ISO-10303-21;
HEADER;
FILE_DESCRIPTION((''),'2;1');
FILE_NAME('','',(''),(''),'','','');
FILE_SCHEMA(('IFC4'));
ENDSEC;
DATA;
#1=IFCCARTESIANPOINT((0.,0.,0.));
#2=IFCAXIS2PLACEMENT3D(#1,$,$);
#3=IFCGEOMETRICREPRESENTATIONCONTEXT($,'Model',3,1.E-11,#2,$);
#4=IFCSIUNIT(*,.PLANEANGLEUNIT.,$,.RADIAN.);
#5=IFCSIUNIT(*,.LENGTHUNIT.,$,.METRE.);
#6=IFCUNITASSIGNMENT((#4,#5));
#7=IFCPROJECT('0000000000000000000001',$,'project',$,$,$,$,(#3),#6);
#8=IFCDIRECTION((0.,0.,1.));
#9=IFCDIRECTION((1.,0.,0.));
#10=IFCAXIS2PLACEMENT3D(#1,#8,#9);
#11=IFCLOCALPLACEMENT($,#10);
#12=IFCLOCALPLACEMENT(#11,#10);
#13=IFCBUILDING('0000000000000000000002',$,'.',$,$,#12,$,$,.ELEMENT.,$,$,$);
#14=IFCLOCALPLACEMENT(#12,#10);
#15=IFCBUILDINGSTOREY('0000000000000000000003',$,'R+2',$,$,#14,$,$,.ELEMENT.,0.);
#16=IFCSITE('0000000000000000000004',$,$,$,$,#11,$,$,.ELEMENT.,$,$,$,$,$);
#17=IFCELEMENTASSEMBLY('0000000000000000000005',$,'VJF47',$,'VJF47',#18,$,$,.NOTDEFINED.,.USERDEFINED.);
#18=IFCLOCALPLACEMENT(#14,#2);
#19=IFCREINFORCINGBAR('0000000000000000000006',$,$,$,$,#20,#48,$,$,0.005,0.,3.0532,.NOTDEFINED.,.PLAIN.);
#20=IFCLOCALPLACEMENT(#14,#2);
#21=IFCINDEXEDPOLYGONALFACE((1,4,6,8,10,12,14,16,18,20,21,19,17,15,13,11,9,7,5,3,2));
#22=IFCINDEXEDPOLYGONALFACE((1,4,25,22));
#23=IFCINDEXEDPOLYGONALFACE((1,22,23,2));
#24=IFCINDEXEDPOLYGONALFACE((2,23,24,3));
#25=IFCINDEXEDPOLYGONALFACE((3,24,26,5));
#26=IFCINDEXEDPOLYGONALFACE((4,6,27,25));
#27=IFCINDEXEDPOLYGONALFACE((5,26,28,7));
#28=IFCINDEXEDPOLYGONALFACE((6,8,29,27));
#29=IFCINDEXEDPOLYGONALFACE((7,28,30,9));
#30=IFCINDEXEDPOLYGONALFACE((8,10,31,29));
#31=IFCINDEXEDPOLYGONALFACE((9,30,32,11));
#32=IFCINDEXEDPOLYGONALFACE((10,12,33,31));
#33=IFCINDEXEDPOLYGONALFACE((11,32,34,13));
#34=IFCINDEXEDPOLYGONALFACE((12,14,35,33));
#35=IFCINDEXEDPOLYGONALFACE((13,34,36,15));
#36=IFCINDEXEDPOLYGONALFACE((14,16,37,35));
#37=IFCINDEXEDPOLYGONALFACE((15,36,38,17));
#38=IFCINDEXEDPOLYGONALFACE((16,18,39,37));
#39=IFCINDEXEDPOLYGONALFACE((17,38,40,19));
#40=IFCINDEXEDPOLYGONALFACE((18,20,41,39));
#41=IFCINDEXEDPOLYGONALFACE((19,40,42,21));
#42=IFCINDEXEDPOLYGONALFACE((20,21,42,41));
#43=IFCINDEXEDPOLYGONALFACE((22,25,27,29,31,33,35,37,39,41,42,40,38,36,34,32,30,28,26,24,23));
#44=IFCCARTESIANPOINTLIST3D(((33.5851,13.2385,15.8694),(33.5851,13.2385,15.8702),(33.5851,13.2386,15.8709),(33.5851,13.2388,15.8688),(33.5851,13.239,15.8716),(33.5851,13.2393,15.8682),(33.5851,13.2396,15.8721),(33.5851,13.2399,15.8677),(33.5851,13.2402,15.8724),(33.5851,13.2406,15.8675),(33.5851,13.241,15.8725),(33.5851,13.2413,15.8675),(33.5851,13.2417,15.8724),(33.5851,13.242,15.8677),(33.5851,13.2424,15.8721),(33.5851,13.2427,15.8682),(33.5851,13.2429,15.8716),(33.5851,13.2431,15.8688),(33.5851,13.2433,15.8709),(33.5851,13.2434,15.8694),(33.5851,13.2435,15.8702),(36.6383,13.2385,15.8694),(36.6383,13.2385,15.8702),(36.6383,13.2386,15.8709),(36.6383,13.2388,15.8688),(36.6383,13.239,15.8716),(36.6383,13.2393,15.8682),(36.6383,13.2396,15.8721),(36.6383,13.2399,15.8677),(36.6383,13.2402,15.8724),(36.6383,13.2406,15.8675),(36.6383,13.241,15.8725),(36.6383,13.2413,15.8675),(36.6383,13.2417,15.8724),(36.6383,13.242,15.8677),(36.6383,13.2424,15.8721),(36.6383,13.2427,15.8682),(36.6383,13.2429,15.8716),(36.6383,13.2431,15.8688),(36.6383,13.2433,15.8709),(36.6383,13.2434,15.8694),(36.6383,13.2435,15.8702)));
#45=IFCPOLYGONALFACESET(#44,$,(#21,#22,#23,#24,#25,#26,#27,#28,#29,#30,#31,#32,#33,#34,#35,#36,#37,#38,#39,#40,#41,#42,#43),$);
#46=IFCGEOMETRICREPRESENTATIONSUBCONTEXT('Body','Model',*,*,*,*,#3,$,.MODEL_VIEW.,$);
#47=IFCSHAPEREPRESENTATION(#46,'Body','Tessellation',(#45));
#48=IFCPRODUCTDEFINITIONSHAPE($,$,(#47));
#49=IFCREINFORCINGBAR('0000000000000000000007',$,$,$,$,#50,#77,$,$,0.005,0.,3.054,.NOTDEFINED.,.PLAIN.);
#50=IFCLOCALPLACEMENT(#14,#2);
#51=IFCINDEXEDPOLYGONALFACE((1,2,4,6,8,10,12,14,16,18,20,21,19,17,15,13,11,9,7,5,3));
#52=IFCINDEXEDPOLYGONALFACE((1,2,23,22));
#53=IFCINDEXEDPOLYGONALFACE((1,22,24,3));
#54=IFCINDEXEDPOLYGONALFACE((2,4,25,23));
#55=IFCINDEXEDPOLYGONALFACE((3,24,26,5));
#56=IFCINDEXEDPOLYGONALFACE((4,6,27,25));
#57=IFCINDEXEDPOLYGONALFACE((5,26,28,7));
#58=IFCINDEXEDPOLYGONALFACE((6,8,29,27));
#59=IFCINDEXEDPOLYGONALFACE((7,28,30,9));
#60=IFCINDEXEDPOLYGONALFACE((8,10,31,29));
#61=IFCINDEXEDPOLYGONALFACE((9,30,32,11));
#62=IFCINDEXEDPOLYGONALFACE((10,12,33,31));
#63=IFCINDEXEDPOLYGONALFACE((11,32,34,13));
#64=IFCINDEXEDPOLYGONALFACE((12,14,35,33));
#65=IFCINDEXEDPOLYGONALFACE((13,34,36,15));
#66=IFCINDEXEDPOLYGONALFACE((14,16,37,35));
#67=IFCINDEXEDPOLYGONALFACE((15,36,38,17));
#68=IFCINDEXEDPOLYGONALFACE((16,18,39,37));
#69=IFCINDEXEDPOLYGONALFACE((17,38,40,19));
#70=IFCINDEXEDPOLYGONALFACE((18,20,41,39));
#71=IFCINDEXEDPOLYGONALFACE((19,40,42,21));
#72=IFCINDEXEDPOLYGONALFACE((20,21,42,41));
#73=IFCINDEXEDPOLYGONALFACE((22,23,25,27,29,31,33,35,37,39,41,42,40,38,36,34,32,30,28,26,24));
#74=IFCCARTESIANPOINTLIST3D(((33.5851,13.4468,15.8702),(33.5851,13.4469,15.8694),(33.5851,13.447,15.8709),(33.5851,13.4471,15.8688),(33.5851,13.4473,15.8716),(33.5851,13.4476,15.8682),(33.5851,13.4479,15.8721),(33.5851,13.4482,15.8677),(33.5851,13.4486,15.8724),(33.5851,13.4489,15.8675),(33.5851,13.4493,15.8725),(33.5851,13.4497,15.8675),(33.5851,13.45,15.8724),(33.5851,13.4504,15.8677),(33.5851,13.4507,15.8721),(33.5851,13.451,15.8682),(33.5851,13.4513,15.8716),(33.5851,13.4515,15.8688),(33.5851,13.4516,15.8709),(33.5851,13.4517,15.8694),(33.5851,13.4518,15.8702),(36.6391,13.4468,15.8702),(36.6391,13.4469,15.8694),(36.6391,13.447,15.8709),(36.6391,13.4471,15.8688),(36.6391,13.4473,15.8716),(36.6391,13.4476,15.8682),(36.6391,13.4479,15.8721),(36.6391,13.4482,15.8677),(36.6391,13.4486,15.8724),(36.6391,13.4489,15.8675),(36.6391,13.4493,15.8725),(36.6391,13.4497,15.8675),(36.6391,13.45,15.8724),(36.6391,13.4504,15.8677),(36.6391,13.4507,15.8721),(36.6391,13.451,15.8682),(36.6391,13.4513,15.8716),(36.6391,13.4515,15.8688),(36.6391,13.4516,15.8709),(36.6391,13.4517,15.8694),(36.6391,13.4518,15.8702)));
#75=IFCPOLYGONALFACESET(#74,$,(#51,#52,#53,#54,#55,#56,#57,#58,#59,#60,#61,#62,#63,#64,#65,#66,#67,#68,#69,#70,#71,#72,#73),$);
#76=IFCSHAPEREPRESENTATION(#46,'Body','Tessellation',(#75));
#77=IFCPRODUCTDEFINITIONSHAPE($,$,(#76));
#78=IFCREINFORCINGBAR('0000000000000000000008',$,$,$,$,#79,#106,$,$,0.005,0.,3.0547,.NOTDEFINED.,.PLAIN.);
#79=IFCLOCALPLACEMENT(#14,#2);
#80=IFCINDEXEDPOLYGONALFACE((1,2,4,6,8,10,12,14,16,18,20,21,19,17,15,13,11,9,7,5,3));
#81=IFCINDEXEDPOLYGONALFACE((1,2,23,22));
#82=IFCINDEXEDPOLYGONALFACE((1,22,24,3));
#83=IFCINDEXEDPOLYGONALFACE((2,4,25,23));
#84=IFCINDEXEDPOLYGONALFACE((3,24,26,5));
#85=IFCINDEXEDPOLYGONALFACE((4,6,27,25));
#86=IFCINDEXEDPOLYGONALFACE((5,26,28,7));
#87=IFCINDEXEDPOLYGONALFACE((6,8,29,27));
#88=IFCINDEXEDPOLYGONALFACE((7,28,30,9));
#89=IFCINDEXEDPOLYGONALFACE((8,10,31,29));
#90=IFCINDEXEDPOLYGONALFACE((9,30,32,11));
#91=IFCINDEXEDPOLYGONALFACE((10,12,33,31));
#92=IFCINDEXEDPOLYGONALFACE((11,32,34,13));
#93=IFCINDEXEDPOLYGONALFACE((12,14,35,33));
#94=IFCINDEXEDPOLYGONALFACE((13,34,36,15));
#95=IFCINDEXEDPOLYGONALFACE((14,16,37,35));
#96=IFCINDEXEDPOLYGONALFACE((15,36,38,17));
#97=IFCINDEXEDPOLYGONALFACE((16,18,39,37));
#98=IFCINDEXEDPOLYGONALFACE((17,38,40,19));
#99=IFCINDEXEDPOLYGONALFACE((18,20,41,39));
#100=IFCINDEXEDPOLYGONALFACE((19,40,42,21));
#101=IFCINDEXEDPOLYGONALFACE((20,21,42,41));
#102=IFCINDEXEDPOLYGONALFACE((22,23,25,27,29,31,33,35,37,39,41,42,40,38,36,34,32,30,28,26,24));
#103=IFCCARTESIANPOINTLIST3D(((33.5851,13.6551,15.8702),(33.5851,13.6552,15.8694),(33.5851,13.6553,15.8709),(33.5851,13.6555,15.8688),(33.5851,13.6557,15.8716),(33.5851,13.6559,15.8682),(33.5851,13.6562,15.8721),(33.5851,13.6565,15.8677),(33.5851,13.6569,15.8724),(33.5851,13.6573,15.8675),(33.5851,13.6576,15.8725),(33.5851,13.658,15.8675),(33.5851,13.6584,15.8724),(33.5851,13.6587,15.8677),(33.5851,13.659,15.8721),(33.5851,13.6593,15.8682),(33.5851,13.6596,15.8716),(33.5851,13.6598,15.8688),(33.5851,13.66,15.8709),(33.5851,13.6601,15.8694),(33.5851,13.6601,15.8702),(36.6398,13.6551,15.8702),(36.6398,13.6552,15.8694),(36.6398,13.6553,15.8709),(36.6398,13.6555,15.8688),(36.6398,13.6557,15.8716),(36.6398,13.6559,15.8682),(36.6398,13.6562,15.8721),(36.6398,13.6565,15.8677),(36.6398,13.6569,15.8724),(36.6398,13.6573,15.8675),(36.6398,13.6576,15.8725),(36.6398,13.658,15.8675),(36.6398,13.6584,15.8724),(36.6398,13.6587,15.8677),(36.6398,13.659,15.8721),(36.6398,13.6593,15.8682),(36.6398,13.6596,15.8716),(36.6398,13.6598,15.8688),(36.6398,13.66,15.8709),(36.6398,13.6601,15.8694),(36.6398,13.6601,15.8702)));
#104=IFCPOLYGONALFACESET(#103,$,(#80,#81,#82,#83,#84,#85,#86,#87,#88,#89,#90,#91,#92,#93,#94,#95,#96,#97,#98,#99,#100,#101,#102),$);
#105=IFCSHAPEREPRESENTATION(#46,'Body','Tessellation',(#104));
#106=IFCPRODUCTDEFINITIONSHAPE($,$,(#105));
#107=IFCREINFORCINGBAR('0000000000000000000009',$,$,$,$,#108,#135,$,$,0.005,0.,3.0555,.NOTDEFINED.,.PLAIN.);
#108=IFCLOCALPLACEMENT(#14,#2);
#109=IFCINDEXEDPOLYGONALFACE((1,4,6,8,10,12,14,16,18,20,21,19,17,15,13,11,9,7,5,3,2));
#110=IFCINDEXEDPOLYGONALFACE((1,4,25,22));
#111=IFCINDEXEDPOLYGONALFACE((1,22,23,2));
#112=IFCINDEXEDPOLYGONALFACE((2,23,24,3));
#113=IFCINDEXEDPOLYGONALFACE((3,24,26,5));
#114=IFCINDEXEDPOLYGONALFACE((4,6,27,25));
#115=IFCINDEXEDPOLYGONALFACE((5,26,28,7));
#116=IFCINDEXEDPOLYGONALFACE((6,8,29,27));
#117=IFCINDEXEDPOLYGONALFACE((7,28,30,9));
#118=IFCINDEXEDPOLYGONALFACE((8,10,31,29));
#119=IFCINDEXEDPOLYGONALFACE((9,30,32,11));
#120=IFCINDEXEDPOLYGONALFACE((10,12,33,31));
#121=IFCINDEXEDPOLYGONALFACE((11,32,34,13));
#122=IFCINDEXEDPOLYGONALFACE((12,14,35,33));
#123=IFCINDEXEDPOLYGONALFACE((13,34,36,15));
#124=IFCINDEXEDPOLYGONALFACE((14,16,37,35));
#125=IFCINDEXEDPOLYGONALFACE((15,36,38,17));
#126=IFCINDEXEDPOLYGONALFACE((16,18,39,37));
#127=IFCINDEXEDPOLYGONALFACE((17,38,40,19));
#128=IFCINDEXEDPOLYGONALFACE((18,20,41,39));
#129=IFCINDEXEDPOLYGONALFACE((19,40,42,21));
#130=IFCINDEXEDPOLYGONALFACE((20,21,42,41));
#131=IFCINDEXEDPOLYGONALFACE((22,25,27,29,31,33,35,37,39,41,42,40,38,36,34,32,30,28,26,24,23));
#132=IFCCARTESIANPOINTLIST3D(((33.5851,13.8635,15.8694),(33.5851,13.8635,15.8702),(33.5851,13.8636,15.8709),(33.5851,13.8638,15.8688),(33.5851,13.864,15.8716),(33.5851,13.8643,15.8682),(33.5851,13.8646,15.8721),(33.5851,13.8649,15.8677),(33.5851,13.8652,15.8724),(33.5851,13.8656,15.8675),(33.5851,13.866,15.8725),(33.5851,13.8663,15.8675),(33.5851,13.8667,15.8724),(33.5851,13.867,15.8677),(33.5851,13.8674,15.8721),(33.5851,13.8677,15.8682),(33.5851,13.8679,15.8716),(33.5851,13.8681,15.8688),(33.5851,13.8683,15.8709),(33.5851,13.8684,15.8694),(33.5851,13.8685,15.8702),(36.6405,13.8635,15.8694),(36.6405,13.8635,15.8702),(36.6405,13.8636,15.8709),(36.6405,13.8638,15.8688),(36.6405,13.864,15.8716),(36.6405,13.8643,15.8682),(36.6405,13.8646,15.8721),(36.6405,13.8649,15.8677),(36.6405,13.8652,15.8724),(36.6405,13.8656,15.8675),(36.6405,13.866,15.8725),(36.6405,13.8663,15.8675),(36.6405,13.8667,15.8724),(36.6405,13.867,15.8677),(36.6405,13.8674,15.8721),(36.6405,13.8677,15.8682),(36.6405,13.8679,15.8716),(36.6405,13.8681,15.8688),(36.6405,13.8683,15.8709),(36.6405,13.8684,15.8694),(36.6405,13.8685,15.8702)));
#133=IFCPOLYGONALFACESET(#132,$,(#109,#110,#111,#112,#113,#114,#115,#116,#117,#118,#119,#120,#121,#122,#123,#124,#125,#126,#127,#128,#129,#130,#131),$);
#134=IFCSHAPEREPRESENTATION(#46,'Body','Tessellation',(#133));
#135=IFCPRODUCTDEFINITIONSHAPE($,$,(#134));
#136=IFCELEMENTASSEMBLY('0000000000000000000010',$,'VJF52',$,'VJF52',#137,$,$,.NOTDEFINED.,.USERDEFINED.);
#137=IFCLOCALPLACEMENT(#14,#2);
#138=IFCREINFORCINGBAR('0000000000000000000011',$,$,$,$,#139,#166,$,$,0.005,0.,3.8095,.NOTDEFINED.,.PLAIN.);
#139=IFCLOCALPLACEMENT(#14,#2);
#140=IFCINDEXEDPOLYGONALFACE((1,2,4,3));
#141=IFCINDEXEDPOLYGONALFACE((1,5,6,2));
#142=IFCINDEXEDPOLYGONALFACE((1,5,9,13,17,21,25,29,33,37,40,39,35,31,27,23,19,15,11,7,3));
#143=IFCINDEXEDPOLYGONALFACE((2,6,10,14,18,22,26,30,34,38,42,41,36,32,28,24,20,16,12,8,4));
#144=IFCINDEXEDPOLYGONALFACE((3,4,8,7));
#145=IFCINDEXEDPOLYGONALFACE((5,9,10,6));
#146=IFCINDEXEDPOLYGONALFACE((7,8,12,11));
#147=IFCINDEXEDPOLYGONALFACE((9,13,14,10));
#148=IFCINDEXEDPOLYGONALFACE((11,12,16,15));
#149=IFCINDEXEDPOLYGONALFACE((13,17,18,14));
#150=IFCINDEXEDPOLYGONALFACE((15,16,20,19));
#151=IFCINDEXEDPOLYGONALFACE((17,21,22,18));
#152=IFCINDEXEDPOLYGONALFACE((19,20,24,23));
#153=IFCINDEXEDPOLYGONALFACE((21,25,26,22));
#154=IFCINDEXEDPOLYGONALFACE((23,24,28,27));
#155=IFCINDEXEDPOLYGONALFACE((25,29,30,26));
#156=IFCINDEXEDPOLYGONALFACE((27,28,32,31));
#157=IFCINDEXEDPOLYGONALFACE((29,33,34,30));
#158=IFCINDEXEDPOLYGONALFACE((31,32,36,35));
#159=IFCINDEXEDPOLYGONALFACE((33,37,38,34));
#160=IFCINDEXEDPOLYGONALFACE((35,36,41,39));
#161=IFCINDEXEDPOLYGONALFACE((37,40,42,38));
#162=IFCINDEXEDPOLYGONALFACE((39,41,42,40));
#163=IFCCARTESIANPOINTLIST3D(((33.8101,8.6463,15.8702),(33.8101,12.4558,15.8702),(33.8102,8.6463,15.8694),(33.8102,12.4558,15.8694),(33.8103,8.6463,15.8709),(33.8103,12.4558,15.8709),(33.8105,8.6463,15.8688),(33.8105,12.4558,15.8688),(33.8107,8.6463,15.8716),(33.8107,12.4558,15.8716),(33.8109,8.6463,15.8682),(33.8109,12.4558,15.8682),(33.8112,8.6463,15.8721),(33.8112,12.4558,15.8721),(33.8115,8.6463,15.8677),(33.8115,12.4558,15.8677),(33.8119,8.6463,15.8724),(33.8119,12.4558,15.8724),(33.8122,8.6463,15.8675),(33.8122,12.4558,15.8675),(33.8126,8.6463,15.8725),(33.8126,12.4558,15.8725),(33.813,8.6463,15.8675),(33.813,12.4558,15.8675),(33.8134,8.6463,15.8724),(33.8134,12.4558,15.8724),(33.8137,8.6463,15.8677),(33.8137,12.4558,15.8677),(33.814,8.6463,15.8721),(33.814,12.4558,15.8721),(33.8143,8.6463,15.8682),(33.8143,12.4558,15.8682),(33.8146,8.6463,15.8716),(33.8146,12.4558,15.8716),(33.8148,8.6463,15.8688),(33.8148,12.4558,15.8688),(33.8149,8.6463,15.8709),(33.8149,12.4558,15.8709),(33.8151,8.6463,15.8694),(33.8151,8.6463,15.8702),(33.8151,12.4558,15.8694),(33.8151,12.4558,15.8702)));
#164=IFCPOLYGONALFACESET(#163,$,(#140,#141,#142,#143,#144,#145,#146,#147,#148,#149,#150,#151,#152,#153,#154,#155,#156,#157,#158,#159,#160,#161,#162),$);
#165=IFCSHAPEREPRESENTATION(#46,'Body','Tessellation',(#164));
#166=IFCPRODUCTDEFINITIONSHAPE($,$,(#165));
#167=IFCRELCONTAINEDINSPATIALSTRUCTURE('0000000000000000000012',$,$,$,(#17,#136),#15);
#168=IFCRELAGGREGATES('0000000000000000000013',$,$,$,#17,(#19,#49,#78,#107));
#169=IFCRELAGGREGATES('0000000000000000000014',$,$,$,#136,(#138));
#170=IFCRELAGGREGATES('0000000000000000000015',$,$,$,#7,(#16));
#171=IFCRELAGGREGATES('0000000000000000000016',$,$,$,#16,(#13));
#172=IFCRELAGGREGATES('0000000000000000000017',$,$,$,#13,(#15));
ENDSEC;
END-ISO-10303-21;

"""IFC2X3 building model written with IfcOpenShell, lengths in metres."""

from ifc_helpers import new_model, entity, si_unit, origin, origin_with_axes, place, context, subcontext, project, spatial, shape, element, aggregate, save


model = new_model("IFC2X3")

# Units and contexts
model_context = context("Model", 3, precision=1e-11, world=origin())
body_context = subcontext(model_context, "Body", "Model", "MODEL_VIEW")
ifc_project = project(units=[si_unit("PLANEANGLEUNIT", "RADIAN"), si_unit("LENGTHUNIT", "METRE")], contexts=[model_context])

# Site, building, storey
site_placement = place(None, origin_with_axes())
site = spatial("IfcSite", under=ifc_project, at=site_placement, CompositionType="ELEMENT")
building_placement = place(site_placement, origin_with_axes())
building = spatial("IfcBuilding", under=site, at=building_placement, Name=".", CompositionType="ELEMENT")
storey_placement = place(building_placement, origin_with_axes())
storey = spatial("IfcBuildingStorey", under=building, at=storey_placement, Name="R+2", CompositionType="ELEMENT", Elevation=0.0)

# Element assemblies, reinforcing bars
assembly_1_placement = place(storey_placement, origin_with_axes())
assembly_1 = element("IfcElementAssembly", 1, at=assembly_1_placement, inside=storey, Name="VJF47", ObjectType="VJF47", AssemblyPlace="NOTDEFINED", PredefinedType="USERDEFINED")
reinforcing_bar_1_placement = place(assembly_1_placement, origin_with_axes())
reinforcing_bar_1 = element("IfcReinforcingBar", 2, at=reinforcing_bar_1_placement, BarLength=3.0532, BarRole="NOTDEFINED", BarSurface="PLAIN", CrossSectionArea=0.0, NominalDiameter=0.005, shapes=[
    shape(body_context, "Body", "AdvancedSweptSolid", [entity("IfcSweptDiskSolid", entity("IfcPolyline", [entity("IfcCartesianPoint", [33.5851, 13.241, 15.87]), entity("IfcCartesianPoint", [36.6383, 13.241, 15.87])]), 0.0025, None, 0.0, 3.0532)]),
    shape(body_context, "Body", "AdvancedSweptSolid", [entity("IfcSweptDiskSolid", entity("IfcPolyline", [entity("IfcCartesianPoint", [33.5851, 13.241, 15.87]), entity("IfcCartesianPoint", [36.6383, 13.241, 15.87])]), 0.0025, None, 0.0, 3.0532)]),
])
reinforcing_bar_2_placement = place(assembly_1_placement, origin_with_axes())
reinforcing_bar_2 = element("IfcReinforcingBar", 3, at=reinforcing_bar_2_placement, BarLength=3.054, BarRole="NOTDEFINED", BarSurface="PLAIN", CrossSectionArea=0.0, NominalDiameter=0.005, shapes=[
    shape(body_context, "Body", "AdvancedSweptSolid", [entity("IfcSweptDiskSolid", entity("IfcPolyline", [entity("IfcCartesianPoint", [33.5851, 13.4493, 15.87]), entity("IfcCartesianPoint", [36.6391, 13.4493, 15.87])]), 0.0025, None, 0.0, 3.054)]),
    shape(body_context, "Body", "AdvancedSweptSolid", [entity("IfcSweptDiskSolid", entity("IfcPolyline", [entity("IfcCartesianPoint", [33.5851, 13.4493, 15.87]), entity("IfcCartesianPoint", [36.6391, 13.4493, 15.87])]), 0.0025, None, 0.0, 3.054)]),
])
reinforcing_bar_3_placement = place(assembly_1_placement, origin_with_axes())
reinforcing_bar_3 = element("IfcReinforcingBar", 4, at=reinforcing_bar_3_placement, BarLength=3.0547, BarRole="NOTDEFINED", BarSurface="PLAIN", CrossSectionArea=0.0, NominalDiameter=0.005, shapes=[
    shape(body_context, "Body", "AdvancedSweptSolid", [entity("IfcSweptDiskSolid", entity("IfcPolyline", [entity("IfcCartesianPoint", [33.5851, 13.6576, 15.87]), entity("IfcCartesianPoint", [36.6398, 13.6576, 15.87])]), 0.0025, None, 0.0, 3.0547)]),
    shape(body_context, "Body", "AdvancedSweptSolid", [entity("IfcSweptDiskSolid", entity("IfcPolyline", [entity("IfcCartesianPoint", [33.5851, 13.6576, 15.87]), entity("IfcCartesianPoint", [36.6398, 13.6576, 15.87])]), 0.0025, None, 0.0, 3.0547)]),
])
reinforcing_bar_4_placement = place(assembly_1_placement, origin_with_axes())
reinforcing_bar_4 = element("IfcReinforcingBar", 5, at=reinforcing_bar_4_placement, BarLength=3.0555, BarRole="NOTDEFINED", BarSurface="PLAIN", CrossSectionArea=0.0, NominalDiameter=0.005, shapes=[
    shape(body_context, "Body", "AdvancedSweptSolid", [entity("IfcSweptDiskSolid", entity("IfcPolyline", [entity("IfcCartesianPoint", [33.5851, 13.866, 15.87]), entity("IfcCartesianPoint", [36.6405, 13.866, 15.87])]), 0.0025, None, 0.0, 3.0555)]),
    shape(body_context, "Body", "AdvancedSweptSolid", [entity("IfcSweptDiskSolid", entity("IfcPolyline", [entity("IfcCartesianPoint", [33.5851, 13.866, 15.87]), entity("IfcCartesianPoint", [36.6405, 13.866, 15.87])]), 0.0025, None, 0.0, 3.0555)]),
])
aggregate(assembly_1, [reinforcing_bar_1, reinforcing_bar_2, reinforcing_bar_3, reinforcing_bar_4])
assembly_2_placement = place(storey_placement, origin_with_axes())
assembly_2 = element("IfcElementAssembly", 6, at=assembly_2_placement, inside=storey, Name="VJF52", ObjectType="VJF52", AssemblyPlace="NOTDEFINED", PredefinedType="USERDEFINED")
reinforcing_bar_5_placement = place(assembly_2_placement, origin_with_axes())
reinforcing_bar_5 = element("IfcReinforcingBar", 7, at=reinforcing_bar_5_placement, BarLength=3.8095, BarRole="NOTDEFINED", BarSurface="PLAIN", CrossSectionArea=0.0, NominalDiameter=0.005, shapes=[
    shape(body_context, "Body", "AdvancedSweptSolid", [entity("IfcSweptDiskSolid", entity("IfcPolyline", [entity("IfcCartesianPoint", [33.8126, 8.6463, 15.87]), entity("IfcCartesianPoint", [33.8126, 12.4558, 15.87])]), 0.0025, None, 0.0, 3.8095)]),
    shape(body_context, "Body", "AdvancedSweptSolid", [entity("IfcSweptDiskSolid", entity("IfcPolyline", [entity("IfcCartesianPoint", [33.8126, 8.6463, 15.87]), entity("IfcCartesianPoint", [33.8126, 12.4558, 15.87])]), 0.0025, None, 0.0, 3.8095)]),
])
aggregate(assembly_2, [reinforcing_bar_5])

save(model, "model.ifc")
